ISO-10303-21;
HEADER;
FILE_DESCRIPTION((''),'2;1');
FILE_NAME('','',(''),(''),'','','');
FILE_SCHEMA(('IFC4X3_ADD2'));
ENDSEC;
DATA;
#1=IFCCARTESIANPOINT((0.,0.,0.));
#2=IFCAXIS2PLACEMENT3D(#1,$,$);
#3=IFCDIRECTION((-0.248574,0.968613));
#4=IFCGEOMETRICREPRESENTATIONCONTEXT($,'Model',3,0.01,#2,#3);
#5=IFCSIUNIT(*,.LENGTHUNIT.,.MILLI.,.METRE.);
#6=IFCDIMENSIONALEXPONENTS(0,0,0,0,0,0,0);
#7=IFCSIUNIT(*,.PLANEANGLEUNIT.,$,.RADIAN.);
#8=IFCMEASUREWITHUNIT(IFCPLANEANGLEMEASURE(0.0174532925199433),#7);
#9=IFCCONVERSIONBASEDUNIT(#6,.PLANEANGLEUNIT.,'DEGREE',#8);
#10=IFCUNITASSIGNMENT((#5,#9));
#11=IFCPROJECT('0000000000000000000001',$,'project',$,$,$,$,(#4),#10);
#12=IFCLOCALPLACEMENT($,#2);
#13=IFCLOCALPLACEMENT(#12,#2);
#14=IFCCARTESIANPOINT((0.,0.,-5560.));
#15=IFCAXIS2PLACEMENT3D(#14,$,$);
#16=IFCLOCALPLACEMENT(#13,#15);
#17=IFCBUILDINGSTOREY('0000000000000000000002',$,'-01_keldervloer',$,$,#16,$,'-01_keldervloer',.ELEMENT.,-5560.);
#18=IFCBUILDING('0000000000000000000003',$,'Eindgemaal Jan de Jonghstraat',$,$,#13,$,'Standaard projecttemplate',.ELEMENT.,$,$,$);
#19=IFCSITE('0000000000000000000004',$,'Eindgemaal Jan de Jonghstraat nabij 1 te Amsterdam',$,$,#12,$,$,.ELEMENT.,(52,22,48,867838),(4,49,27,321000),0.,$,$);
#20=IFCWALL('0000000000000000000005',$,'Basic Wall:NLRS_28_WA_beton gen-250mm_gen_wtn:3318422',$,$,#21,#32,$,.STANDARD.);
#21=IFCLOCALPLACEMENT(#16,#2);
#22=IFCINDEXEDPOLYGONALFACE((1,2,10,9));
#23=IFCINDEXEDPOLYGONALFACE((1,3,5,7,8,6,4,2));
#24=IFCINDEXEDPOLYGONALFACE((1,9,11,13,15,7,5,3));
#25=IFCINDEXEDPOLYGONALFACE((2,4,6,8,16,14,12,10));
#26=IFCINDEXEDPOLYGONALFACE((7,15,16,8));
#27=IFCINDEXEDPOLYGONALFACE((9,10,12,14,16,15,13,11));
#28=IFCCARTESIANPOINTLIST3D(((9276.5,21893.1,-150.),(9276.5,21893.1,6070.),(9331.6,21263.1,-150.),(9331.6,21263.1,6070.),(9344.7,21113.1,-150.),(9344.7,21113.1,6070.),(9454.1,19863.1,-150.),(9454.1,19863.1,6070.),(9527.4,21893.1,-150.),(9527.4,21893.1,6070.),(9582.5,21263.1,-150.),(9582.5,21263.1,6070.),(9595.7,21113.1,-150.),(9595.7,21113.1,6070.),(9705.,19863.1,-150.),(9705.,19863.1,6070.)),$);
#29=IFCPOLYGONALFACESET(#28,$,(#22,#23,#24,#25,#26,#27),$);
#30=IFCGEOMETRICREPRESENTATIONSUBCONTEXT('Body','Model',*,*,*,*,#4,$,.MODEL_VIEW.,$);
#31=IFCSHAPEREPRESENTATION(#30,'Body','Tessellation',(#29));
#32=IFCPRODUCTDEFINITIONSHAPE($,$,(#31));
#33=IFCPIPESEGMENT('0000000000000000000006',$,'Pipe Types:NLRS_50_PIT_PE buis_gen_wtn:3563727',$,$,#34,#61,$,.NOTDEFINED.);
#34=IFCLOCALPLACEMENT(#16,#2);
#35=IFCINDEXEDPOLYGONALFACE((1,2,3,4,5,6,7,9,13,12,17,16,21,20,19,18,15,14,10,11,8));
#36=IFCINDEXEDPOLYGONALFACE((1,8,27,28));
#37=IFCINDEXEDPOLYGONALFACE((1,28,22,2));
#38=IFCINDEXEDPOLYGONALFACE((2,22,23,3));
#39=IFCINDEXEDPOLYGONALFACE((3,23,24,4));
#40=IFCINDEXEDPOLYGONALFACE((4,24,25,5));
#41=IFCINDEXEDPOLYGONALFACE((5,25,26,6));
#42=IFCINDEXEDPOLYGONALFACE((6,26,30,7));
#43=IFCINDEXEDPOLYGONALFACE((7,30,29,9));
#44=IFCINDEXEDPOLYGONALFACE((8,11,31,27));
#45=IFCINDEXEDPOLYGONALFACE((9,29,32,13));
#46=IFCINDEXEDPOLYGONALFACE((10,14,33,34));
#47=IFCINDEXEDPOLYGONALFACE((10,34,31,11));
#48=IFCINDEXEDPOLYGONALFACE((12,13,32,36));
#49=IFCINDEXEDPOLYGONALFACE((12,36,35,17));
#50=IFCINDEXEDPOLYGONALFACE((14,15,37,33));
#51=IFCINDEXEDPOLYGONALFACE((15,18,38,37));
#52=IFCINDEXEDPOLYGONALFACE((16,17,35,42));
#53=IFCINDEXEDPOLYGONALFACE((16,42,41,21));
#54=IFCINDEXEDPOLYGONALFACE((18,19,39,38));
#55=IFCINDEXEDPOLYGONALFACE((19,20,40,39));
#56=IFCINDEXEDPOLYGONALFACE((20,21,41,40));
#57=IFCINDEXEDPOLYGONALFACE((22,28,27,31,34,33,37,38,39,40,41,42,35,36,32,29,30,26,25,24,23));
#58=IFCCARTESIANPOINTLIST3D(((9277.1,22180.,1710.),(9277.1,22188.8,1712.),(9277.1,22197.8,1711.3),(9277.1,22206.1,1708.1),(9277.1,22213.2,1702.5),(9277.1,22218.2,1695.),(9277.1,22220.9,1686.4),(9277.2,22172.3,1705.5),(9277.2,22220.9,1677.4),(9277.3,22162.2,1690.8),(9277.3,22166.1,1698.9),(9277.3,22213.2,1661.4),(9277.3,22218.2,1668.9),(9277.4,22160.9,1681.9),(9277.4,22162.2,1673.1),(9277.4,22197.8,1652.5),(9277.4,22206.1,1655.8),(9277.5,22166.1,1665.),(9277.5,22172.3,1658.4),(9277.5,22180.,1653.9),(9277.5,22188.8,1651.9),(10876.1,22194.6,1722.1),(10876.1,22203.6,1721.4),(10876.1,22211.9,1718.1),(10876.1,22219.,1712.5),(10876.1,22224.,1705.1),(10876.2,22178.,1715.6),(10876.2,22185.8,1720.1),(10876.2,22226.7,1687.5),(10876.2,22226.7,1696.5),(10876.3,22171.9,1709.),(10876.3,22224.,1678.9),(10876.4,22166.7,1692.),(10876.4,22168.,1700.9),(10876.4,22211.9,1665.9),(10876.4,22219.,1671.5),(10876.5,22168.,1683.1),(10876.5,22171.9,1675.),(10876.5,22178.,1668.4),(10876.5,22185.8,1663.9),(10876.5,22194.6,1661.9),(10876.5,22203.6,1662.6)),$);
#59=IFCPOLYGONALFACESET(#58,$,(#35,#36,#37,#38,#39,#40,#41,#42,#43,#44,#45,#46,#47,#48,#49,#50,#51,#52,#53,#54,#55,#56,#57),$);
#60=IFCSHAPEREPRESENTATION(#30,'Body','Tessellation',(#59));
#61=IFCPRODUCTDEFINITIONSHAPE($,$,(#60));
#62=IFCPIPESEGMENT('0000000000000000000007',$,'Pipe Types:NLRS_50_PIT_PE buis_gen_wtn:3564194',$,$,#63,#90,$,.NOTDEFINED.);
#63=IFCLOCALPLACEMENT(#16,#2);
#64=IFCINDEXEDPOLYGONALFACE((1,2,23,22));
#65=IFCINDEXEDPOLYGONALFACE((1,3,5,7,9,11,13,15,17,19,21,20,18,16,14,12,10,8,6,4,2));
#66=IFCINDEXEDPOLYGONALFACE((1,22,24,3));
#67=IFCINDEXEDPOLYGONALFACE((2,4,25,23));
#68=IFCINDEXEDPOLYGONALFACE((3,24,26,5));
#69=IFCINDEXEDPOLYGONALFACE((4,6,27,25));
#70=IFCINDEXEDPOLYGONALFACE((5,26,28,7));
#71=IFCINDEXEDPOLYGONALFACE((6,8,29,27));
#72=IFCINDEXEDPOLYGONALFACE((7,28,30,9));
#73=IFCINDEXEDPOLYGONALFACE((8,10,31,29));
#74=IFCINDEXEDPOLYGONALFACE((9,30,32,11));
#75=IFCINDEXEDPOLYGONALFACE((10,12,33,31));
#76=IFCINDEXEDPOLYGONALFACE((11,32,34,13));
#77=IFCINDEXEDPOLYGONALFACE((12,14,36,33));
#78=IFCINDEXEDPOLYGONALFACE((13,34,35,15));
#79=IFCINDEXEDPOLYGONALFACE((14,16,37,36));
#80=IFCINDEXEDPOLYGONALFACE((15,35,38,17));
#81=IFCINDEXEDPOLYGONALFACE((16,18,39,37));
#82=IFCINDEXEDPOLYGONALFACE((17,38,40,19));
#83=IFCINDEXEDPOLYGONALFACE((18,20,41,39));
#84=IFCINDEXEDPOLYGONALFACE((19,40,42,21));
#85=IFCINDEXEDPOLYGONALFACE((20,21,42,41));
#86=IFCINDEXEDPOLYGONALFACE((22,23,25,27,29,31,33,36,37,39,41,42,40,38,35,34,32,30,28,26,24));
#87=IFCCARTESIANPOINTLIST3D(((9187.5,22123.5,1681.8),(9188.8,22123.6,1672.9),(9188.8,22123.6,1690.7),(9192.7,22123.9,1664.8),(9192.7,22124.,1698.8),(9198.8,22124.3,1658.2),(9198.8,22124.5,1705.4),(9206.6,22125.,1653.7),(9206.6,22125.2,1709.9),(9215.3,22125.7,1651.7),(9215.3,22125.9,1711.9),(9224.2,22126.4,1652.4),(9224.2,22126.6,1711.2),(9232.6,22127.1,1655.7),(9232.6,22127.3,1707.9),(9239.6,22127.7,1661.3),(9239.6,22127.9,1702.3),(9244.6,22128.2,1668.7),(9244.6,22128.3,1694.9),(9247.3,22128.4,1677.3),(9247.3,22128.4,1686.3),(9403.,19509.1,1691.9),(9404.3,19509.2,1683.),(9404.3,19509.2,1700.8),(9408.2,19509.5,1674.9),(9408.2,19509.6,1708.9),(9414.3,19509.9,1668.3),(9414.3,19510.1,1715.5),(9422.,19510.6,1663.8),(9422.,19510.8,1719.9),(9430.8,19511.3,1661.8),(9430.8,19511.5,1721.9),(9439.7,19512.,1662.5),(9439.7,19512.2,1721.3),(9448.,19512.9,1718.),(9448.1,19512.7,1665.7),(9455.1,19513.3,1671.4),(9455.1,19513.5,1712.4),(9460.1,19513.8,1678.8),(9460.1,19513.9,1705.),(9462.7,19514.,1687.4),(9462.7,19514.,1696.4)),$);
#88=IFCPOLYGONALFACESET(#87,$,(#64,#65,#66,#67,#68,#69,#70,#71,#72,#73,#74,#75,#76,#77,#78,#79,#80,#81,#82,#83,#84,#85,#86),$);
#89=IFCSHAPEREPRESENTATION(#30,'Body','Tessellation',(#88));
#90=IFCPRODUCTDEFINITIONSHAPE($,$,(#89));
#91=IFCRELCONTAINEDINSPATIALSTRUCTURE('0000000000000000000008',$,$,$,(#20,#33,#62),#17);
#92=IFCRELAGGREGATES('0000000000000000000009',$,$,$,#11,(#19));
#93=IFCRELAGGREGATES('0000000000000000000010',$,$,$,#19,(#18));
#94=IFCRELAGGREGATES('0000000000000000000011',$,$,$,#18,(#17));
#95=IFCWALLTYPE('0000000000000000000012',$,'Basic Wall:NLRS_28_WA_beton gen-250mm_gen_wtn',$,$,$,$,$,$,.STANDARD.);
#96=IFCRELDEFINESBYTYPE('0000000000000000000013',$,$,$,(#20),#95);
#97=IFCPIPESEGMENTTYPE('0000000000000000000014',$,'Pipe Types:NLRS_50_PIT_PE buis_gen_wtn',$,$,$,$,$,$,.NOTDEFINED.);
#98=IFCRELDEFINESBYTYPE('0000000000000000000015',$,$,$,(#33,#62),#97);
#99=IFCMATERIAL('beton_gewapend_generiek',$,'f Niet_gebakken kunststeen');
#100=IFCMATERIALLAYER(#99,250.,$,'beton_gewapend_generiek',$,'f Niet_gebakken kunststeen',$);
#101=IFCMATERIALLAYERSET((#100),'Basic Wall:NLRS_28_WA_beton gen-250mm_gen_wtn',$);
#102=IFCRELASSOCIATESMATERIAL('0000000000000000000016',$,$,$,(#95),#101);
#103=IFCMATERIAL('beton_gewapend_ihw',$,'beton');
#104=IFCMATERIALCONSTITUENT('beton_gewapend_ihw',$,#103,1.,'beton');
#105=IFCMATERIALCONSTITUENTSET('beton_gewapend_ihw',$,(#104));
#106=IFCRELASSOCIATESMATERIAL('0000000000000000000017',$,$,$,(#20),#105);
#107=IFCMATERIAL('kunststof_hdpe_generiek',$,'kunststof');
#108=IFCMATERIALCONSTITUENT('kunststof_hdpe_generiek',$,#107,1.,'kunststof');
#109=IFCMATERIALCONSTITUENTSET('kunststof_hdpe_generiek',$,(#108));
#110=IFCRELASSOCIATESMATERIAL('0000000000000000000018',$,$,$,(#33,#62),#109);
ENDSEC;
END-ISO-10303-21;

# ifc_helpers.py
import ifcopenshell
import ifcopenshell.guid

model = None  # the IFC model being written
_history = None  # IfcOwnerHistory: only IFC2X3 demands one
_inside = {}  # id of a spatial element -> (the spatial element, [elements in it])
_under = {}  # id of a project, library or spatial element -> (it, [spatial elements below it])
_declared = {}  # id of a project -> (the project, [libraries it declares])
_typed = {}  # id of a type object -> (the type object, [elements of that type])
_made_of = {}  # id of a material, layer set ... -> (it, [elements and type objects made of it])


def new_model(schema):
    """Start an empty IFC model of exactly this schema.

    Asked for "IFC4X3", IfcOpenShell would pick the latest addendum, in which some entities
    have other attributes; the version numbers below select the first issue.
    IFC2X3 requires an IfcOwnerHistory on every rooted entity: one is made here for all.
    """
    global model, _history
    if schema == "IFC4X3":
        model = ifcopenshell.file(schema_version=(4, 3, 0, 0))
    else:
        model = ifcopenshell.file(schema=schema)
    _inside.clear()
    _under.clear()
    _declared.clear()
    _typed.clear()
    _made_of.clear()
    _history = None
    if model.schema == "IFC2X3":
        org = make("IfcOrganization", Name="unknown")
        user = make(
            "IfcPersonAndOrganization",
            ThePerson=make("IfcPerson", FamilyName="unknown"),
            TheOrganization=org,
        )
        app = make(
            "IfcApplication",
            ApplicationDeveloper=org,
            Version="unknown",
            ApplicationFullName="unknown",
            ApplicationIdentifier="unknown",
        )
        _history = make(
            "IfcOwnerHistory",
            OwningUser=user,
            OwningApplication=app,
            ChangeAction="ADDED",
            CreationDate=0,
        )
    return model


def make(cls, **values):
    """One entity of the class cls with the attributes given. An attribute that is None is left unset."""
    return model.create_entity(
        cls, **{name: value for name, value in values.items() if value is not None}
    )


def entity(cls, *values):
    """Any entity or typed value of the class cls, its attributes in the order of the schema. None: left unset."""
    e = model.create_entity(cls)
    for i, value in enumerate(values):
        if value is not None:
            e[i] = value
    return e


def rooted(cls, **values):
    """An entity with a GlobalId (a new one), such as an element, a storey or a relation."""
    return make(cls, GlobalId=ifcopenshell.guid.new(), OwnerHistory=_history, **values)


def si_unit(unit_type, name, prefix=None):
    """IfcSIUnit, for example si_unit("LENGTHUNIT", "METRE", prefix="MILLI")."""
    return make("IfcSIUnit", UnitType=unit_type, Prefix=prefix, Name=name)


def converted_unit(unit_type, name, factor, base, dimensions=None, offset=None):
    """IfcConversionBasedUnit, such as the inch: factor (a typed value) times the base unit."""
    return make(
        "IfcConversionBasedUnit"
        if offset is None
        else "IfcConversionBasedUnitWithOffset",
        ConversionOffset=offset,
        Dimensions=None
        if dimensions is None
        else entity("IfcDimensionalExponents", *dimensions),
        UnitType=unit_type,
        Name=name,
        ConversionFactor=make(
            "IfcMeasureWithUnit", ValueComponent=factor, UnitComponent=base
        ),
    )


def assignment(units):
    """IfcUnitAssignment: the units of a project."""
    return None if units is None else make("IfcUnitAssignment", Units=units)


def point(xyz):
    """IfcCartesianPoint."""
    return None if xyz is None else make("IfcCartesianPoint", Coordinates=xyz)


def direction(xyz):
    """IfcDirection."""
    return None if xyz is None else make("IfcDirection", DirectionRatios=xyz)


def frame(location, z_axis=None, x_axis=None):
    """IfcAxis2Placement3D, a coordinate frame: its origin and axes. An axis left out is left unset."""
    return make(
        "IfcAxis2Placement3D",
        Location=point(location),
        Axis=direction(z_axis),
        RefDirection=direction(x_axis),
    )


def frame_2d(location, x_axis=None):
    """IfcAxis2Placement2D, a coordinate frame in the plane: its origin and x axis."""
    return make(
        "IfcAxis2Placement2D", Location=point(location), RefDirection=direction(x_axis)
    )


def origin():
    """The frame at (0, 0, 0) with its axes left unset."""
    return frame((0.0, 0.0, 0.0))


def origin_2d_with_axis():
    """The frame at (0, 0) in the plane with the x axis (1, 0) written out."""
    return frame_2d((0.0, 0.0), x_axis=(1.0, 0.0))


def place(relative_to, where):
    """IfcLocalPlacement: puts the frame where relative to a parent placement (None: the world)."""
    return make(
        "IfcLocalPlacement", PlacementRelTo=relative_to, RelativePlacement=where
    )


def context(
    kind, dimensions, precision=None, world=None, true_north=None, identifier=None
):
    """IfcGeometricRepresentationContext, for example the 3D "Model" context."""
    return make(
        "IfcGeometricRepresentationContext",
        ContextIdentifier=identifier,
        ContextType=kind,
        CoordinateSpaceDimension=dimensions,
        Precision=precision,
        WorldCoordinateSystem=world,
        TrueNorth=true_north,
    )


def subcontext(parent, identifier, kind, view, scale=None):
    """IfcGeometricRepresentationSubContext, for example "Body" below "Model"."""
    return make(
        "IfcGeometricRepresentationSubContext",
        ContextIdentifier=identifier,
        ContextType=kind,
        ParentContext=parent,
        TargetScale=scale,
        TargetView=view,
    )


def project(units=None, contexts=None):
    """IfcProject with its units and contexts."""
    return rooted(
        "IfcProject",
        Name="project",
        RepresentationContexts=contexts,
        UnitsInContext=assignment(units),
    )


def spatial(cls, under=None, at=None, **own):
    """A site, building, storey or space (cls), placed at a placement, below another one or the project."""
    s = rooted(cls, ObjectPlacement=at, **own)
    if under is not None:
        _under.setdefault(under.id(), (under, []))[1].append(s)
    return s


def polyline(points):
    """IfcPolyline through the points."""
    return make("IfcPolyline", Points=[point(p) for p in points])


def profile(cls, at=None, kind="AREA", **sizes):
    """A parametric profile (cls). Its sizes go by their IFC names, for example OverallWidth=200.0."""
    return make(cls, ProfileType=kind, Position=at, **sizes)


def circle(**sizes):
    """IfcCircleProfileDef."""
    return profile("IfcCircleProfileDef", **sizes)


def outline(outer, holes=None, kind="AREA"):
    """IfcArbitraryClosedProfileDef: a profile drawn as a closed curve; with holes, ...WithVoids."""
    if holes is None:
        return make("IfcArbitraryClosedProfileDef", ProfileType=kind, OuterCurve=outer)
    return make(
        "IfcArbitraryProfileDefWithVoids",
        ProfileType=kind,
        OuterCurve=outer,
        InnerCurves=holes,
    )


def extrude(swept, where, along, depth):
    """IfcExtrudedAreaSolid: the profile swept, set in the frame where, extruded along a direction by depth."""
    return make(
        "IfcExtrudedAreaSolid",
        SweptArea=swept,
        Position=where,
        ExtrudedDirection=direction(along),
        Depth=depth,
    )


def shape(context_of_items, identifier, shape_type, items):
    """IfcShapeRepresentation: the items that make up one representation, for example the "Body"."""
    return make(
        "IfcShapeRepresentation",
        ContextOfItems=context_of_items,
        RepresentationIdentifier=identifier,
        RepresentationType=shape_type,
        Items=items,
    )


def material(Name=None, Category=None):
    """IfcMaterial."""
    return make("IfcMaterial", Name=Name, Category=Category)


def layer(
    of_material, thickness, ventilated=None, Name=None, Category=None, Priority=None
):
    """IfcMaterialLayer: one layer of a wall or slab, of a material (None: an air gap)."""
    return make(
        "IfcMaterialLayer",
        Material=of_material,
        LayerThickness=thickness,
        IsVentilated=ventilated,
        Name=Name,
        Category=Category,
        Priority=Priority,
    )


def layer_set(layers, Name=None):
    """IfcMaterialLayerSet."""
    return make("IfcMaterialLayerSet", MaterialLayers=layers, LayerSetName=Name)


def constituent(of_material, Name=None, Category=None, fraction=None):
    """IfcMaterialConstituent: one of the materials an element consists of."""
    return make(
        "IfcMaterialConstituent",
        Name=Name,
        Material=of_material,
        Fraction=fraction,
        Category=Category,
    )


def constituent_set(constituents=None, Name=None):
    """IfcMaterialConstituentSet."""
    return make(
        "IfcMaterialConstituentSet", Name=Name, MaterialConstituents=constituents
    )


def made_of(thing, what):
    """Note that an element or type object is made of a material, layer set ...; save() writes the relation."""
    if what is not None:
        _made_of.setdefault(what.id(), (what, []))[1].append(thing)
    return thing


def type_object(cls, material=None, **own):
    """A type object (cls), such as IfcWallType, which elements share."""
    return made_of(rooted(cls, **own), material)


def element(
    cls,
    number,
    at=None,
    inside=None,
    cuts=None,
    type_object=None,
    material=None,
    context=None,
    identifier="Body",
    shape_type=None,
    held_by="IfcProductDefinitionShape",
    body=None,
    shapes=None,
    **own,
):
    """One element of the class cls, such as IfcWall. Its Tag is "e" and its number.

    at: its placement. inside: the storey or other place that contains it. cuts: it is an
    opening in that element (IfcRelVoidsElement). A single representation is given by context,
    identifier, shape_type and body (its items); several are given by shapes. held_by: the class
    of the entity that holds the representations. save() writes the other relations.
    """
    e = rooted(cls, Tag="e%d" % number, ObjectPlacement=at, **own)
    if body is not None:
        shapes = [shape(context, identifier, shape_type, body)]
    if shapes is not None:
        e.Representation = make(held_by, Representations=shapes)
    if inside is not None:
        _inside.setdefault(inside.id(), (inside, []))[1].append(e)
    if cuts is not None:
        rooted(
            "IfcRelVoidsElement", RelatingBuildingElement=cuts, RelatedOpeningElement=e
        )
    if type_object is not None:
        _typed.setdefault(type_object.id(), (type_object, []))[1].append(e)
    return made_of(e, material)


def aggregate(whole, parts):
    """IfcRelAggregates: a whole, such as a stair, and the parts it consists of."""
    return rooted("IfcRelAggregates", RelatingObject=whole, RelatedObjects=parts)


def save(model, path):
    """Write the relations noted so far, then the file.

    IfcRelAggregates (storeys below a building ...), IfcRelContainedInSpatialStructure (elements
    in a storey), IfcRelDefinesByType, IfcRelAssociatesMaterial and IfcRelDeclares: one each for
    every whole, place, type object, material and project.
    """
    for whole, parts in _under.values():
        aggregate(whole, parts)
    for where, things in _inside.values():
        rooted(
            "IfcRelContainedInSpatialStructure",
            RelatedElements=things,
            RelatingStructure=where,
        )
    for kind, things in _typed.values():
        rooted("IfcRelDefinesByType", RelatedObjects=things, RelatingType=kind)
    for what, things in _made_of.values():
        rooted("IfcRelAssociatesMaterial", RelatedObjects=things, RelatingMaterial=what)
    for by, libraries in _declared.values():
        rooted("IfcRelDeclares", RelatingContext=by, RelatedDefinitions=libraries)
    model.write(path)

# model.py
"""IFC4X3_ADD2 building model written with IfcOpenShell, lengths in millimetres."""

from ifc_helpers import new_model, entity, si_unit, converted_unit, direction, frame, frame_2d, origin, origin_2d_with_axis, place, context, subcontext, project, spatial, polyline, circle, outline, extrude, material, layer, layer_set, constituent, constituent_set, type_object, element, save


model = new_model("IFC4X3_ADD2")

# Units and contexts
model_context = context("Model", 3, precision=0.01, world=origin(), true_north=direction((-0.248574, 0.968613)))
body_context = subcontext(model_context, "Body", "Model", "MODEL_VIEW")
ifc_project = project(units=[si_unit("LENGTHUNIT", "METRE", prefix="MILLI"), converted_unit("PLANEANGLEUNIT", "DEGREE", entity("IfcPlaneAngleMeasure", 0.0174532925199433), si_unit("PLANEANGLEUNIT", "RADIAN"), dimensions=[0, 0, 0, 0, 0, 0, 0])], contexts=[model_context])

# Site, building, storey
site_placement = place(None, origin())
site = spatial("IfcSite", under=ifc_project, at=site_placement, Name="Eindgemaal Jan de Jonghstraat nabij 1 te Amsterdam", CompositionType="ELEMENT", RefLatitude=(52, 22, 48, 867838), RefLongitude=(4, 49, 27, 321000), RefElevation=0.0)
building_placement = place(site_placement, origin())
building = spatial("IfcBuilding", under=site, at=building_placement, Name="Eindgemaal Jan de Jonghstraat", LongName="Standaard projecttemplate", CompositionType="ELEMENT")
storey_placement = place(building_placement, frame((0.0, 0.0, -5560.0)))
storey = spatial("IfcBuildingStorey", under=building, at=storey_placement, Name="-01_keldervloer", LongName="-01_keldervloer", CompositionType="ELEMENT", Elevation=-5560.0)

# Wall
ifc_material_1 = material(Name="beton_gewapend_ihw", Category="beton")
ifc_constituent_1 = constituent(ifc_material_1, Name="beton_gewapend_ihw", Category="beton", fraction=1.0)
ifc_constituent_set_1 = constituent_set(constituents=[ifc_constituent_1], Name="beton_gewapend_ihw")
ifc_material_2 = material(Name="beton_gewapend_generiek", Category="f Niet_gebakken kunststeen")
ifc_layer = layer(ifc_material_2, 250.0, Name="beton_gewapend_generiek", Category="f Niet_gebakken kunststeen")
ifc_layer_set = layer_set([ifc_layer], Name="Basic Wall:NLRS_28_WA_beton gen-250mm_gen_wtn")
wall_type = type_object("IfcWallType", Name="Basic Wall:NLRS_28_WA_beton gen-250mm_gen_wtn", PredefinedType="STANDARD", material=ifc_layer_set)
wall_placement = place(storey_placement, frame((9580.5, 19852.2, -150.0), z_axis=(0.0, 0.0, 1.0), x_axis=(-0.087156, 0.996195, 0.0)))
element("IfcWall", 1, at=wall_placement, inside=storey, type_object=wall_type, material=ifc_constituent_set_1, Name="Basic Wall:NLRS_28_WA_beton gen-250mm_gen_wtn:3318422", PredefinedType="STANDARD", context=body_context, shape_type="SweptSolid", body=[
    extrude(outline(polyline([(2037.8, -125.0), (2059.6, 125.0), (1427.2, 125.0), (1276.6, 125.0), (21.9, 125.0), (0.0, -125.0), (1254.8, -125.0), (1405.3, -125.0), (2037.8, -125.0)])), origin(), (0.0, 0.0, 1.0), 6220.0),
])

# Pipe segments
ifc_material_3 = material(Name="kunststof_hdpe_generiek", Category="kunststof")
ifc_constituent_2 = constituent(ifc_material_3, Name="kunststof_hdpe_generiek", Category="kunststof", fraction=1.0)
ifc_constituent_set_2 = constituent_set(constituents=[ifc_constituent_2], Name="kunststof_hdpe_generiek")
pipe_segment_type_1 = type_object("IfcPipeSegmentType", Name="Pipe Types:NLRS_50_PIT_PE buis_gen_wtn", PredefinedType="NOTDEFINED")
pipe_segment_1_placement = place(storey_placement, frame((9275.5, 22159.3, 1650.2)))
element("IfcPipeSegment", 2, at=pipe_segment_1_placement, inside=storey, type_object=pipe_segment_type_1, material=ifc_constituent_set_2, Name="Pipe Types:NLRS_50_PIT_PE buis_gen_wtn:3563727", PredefinedType="NOTDEFINED", context=body_context, shape_type="SweptSolid", body=[
    extrude(circle(Radius=30.2, at=frame_2d((0.0, 0.0), x_axis=(1.0, 0.0))), frame((1.8, 31.8, 31.8), z_axis=(0.999974, 0.003618, 0.006307), x_axis=(0.003618, -0.999993, 0.0)), (0.0, 0.0, 1.0), 1599.1),
])
pipe_segment_2_placement = place(storey_placement, frame((9185.9, 19507.5, 1650.0)))
element("IfcPipeSegment", 3, at=pipe_segment_2_placement, inside=storey, type_object=pipe_segment_type_1, material=ifc_constituent_set_2, Name="Pipe Types:NLRS_50_PIT_PE buis_gen_wtn:3564194", PredefinedType="NOTDEFINED", context=body_context, shape_type="SweptSolid", body=[
    extrude(circle(Radius=30.2, at=origin_2d_with_axis()), frame((247.1, 4.1, 41.8), z_axis=(-0.082141, 0.996613, -0.003846), x_axis=(-0.996621, -0.082142, 0.0)), (0.0, 0.0, 1.0), 2623.3),
])

save(model, "model.ifc")
